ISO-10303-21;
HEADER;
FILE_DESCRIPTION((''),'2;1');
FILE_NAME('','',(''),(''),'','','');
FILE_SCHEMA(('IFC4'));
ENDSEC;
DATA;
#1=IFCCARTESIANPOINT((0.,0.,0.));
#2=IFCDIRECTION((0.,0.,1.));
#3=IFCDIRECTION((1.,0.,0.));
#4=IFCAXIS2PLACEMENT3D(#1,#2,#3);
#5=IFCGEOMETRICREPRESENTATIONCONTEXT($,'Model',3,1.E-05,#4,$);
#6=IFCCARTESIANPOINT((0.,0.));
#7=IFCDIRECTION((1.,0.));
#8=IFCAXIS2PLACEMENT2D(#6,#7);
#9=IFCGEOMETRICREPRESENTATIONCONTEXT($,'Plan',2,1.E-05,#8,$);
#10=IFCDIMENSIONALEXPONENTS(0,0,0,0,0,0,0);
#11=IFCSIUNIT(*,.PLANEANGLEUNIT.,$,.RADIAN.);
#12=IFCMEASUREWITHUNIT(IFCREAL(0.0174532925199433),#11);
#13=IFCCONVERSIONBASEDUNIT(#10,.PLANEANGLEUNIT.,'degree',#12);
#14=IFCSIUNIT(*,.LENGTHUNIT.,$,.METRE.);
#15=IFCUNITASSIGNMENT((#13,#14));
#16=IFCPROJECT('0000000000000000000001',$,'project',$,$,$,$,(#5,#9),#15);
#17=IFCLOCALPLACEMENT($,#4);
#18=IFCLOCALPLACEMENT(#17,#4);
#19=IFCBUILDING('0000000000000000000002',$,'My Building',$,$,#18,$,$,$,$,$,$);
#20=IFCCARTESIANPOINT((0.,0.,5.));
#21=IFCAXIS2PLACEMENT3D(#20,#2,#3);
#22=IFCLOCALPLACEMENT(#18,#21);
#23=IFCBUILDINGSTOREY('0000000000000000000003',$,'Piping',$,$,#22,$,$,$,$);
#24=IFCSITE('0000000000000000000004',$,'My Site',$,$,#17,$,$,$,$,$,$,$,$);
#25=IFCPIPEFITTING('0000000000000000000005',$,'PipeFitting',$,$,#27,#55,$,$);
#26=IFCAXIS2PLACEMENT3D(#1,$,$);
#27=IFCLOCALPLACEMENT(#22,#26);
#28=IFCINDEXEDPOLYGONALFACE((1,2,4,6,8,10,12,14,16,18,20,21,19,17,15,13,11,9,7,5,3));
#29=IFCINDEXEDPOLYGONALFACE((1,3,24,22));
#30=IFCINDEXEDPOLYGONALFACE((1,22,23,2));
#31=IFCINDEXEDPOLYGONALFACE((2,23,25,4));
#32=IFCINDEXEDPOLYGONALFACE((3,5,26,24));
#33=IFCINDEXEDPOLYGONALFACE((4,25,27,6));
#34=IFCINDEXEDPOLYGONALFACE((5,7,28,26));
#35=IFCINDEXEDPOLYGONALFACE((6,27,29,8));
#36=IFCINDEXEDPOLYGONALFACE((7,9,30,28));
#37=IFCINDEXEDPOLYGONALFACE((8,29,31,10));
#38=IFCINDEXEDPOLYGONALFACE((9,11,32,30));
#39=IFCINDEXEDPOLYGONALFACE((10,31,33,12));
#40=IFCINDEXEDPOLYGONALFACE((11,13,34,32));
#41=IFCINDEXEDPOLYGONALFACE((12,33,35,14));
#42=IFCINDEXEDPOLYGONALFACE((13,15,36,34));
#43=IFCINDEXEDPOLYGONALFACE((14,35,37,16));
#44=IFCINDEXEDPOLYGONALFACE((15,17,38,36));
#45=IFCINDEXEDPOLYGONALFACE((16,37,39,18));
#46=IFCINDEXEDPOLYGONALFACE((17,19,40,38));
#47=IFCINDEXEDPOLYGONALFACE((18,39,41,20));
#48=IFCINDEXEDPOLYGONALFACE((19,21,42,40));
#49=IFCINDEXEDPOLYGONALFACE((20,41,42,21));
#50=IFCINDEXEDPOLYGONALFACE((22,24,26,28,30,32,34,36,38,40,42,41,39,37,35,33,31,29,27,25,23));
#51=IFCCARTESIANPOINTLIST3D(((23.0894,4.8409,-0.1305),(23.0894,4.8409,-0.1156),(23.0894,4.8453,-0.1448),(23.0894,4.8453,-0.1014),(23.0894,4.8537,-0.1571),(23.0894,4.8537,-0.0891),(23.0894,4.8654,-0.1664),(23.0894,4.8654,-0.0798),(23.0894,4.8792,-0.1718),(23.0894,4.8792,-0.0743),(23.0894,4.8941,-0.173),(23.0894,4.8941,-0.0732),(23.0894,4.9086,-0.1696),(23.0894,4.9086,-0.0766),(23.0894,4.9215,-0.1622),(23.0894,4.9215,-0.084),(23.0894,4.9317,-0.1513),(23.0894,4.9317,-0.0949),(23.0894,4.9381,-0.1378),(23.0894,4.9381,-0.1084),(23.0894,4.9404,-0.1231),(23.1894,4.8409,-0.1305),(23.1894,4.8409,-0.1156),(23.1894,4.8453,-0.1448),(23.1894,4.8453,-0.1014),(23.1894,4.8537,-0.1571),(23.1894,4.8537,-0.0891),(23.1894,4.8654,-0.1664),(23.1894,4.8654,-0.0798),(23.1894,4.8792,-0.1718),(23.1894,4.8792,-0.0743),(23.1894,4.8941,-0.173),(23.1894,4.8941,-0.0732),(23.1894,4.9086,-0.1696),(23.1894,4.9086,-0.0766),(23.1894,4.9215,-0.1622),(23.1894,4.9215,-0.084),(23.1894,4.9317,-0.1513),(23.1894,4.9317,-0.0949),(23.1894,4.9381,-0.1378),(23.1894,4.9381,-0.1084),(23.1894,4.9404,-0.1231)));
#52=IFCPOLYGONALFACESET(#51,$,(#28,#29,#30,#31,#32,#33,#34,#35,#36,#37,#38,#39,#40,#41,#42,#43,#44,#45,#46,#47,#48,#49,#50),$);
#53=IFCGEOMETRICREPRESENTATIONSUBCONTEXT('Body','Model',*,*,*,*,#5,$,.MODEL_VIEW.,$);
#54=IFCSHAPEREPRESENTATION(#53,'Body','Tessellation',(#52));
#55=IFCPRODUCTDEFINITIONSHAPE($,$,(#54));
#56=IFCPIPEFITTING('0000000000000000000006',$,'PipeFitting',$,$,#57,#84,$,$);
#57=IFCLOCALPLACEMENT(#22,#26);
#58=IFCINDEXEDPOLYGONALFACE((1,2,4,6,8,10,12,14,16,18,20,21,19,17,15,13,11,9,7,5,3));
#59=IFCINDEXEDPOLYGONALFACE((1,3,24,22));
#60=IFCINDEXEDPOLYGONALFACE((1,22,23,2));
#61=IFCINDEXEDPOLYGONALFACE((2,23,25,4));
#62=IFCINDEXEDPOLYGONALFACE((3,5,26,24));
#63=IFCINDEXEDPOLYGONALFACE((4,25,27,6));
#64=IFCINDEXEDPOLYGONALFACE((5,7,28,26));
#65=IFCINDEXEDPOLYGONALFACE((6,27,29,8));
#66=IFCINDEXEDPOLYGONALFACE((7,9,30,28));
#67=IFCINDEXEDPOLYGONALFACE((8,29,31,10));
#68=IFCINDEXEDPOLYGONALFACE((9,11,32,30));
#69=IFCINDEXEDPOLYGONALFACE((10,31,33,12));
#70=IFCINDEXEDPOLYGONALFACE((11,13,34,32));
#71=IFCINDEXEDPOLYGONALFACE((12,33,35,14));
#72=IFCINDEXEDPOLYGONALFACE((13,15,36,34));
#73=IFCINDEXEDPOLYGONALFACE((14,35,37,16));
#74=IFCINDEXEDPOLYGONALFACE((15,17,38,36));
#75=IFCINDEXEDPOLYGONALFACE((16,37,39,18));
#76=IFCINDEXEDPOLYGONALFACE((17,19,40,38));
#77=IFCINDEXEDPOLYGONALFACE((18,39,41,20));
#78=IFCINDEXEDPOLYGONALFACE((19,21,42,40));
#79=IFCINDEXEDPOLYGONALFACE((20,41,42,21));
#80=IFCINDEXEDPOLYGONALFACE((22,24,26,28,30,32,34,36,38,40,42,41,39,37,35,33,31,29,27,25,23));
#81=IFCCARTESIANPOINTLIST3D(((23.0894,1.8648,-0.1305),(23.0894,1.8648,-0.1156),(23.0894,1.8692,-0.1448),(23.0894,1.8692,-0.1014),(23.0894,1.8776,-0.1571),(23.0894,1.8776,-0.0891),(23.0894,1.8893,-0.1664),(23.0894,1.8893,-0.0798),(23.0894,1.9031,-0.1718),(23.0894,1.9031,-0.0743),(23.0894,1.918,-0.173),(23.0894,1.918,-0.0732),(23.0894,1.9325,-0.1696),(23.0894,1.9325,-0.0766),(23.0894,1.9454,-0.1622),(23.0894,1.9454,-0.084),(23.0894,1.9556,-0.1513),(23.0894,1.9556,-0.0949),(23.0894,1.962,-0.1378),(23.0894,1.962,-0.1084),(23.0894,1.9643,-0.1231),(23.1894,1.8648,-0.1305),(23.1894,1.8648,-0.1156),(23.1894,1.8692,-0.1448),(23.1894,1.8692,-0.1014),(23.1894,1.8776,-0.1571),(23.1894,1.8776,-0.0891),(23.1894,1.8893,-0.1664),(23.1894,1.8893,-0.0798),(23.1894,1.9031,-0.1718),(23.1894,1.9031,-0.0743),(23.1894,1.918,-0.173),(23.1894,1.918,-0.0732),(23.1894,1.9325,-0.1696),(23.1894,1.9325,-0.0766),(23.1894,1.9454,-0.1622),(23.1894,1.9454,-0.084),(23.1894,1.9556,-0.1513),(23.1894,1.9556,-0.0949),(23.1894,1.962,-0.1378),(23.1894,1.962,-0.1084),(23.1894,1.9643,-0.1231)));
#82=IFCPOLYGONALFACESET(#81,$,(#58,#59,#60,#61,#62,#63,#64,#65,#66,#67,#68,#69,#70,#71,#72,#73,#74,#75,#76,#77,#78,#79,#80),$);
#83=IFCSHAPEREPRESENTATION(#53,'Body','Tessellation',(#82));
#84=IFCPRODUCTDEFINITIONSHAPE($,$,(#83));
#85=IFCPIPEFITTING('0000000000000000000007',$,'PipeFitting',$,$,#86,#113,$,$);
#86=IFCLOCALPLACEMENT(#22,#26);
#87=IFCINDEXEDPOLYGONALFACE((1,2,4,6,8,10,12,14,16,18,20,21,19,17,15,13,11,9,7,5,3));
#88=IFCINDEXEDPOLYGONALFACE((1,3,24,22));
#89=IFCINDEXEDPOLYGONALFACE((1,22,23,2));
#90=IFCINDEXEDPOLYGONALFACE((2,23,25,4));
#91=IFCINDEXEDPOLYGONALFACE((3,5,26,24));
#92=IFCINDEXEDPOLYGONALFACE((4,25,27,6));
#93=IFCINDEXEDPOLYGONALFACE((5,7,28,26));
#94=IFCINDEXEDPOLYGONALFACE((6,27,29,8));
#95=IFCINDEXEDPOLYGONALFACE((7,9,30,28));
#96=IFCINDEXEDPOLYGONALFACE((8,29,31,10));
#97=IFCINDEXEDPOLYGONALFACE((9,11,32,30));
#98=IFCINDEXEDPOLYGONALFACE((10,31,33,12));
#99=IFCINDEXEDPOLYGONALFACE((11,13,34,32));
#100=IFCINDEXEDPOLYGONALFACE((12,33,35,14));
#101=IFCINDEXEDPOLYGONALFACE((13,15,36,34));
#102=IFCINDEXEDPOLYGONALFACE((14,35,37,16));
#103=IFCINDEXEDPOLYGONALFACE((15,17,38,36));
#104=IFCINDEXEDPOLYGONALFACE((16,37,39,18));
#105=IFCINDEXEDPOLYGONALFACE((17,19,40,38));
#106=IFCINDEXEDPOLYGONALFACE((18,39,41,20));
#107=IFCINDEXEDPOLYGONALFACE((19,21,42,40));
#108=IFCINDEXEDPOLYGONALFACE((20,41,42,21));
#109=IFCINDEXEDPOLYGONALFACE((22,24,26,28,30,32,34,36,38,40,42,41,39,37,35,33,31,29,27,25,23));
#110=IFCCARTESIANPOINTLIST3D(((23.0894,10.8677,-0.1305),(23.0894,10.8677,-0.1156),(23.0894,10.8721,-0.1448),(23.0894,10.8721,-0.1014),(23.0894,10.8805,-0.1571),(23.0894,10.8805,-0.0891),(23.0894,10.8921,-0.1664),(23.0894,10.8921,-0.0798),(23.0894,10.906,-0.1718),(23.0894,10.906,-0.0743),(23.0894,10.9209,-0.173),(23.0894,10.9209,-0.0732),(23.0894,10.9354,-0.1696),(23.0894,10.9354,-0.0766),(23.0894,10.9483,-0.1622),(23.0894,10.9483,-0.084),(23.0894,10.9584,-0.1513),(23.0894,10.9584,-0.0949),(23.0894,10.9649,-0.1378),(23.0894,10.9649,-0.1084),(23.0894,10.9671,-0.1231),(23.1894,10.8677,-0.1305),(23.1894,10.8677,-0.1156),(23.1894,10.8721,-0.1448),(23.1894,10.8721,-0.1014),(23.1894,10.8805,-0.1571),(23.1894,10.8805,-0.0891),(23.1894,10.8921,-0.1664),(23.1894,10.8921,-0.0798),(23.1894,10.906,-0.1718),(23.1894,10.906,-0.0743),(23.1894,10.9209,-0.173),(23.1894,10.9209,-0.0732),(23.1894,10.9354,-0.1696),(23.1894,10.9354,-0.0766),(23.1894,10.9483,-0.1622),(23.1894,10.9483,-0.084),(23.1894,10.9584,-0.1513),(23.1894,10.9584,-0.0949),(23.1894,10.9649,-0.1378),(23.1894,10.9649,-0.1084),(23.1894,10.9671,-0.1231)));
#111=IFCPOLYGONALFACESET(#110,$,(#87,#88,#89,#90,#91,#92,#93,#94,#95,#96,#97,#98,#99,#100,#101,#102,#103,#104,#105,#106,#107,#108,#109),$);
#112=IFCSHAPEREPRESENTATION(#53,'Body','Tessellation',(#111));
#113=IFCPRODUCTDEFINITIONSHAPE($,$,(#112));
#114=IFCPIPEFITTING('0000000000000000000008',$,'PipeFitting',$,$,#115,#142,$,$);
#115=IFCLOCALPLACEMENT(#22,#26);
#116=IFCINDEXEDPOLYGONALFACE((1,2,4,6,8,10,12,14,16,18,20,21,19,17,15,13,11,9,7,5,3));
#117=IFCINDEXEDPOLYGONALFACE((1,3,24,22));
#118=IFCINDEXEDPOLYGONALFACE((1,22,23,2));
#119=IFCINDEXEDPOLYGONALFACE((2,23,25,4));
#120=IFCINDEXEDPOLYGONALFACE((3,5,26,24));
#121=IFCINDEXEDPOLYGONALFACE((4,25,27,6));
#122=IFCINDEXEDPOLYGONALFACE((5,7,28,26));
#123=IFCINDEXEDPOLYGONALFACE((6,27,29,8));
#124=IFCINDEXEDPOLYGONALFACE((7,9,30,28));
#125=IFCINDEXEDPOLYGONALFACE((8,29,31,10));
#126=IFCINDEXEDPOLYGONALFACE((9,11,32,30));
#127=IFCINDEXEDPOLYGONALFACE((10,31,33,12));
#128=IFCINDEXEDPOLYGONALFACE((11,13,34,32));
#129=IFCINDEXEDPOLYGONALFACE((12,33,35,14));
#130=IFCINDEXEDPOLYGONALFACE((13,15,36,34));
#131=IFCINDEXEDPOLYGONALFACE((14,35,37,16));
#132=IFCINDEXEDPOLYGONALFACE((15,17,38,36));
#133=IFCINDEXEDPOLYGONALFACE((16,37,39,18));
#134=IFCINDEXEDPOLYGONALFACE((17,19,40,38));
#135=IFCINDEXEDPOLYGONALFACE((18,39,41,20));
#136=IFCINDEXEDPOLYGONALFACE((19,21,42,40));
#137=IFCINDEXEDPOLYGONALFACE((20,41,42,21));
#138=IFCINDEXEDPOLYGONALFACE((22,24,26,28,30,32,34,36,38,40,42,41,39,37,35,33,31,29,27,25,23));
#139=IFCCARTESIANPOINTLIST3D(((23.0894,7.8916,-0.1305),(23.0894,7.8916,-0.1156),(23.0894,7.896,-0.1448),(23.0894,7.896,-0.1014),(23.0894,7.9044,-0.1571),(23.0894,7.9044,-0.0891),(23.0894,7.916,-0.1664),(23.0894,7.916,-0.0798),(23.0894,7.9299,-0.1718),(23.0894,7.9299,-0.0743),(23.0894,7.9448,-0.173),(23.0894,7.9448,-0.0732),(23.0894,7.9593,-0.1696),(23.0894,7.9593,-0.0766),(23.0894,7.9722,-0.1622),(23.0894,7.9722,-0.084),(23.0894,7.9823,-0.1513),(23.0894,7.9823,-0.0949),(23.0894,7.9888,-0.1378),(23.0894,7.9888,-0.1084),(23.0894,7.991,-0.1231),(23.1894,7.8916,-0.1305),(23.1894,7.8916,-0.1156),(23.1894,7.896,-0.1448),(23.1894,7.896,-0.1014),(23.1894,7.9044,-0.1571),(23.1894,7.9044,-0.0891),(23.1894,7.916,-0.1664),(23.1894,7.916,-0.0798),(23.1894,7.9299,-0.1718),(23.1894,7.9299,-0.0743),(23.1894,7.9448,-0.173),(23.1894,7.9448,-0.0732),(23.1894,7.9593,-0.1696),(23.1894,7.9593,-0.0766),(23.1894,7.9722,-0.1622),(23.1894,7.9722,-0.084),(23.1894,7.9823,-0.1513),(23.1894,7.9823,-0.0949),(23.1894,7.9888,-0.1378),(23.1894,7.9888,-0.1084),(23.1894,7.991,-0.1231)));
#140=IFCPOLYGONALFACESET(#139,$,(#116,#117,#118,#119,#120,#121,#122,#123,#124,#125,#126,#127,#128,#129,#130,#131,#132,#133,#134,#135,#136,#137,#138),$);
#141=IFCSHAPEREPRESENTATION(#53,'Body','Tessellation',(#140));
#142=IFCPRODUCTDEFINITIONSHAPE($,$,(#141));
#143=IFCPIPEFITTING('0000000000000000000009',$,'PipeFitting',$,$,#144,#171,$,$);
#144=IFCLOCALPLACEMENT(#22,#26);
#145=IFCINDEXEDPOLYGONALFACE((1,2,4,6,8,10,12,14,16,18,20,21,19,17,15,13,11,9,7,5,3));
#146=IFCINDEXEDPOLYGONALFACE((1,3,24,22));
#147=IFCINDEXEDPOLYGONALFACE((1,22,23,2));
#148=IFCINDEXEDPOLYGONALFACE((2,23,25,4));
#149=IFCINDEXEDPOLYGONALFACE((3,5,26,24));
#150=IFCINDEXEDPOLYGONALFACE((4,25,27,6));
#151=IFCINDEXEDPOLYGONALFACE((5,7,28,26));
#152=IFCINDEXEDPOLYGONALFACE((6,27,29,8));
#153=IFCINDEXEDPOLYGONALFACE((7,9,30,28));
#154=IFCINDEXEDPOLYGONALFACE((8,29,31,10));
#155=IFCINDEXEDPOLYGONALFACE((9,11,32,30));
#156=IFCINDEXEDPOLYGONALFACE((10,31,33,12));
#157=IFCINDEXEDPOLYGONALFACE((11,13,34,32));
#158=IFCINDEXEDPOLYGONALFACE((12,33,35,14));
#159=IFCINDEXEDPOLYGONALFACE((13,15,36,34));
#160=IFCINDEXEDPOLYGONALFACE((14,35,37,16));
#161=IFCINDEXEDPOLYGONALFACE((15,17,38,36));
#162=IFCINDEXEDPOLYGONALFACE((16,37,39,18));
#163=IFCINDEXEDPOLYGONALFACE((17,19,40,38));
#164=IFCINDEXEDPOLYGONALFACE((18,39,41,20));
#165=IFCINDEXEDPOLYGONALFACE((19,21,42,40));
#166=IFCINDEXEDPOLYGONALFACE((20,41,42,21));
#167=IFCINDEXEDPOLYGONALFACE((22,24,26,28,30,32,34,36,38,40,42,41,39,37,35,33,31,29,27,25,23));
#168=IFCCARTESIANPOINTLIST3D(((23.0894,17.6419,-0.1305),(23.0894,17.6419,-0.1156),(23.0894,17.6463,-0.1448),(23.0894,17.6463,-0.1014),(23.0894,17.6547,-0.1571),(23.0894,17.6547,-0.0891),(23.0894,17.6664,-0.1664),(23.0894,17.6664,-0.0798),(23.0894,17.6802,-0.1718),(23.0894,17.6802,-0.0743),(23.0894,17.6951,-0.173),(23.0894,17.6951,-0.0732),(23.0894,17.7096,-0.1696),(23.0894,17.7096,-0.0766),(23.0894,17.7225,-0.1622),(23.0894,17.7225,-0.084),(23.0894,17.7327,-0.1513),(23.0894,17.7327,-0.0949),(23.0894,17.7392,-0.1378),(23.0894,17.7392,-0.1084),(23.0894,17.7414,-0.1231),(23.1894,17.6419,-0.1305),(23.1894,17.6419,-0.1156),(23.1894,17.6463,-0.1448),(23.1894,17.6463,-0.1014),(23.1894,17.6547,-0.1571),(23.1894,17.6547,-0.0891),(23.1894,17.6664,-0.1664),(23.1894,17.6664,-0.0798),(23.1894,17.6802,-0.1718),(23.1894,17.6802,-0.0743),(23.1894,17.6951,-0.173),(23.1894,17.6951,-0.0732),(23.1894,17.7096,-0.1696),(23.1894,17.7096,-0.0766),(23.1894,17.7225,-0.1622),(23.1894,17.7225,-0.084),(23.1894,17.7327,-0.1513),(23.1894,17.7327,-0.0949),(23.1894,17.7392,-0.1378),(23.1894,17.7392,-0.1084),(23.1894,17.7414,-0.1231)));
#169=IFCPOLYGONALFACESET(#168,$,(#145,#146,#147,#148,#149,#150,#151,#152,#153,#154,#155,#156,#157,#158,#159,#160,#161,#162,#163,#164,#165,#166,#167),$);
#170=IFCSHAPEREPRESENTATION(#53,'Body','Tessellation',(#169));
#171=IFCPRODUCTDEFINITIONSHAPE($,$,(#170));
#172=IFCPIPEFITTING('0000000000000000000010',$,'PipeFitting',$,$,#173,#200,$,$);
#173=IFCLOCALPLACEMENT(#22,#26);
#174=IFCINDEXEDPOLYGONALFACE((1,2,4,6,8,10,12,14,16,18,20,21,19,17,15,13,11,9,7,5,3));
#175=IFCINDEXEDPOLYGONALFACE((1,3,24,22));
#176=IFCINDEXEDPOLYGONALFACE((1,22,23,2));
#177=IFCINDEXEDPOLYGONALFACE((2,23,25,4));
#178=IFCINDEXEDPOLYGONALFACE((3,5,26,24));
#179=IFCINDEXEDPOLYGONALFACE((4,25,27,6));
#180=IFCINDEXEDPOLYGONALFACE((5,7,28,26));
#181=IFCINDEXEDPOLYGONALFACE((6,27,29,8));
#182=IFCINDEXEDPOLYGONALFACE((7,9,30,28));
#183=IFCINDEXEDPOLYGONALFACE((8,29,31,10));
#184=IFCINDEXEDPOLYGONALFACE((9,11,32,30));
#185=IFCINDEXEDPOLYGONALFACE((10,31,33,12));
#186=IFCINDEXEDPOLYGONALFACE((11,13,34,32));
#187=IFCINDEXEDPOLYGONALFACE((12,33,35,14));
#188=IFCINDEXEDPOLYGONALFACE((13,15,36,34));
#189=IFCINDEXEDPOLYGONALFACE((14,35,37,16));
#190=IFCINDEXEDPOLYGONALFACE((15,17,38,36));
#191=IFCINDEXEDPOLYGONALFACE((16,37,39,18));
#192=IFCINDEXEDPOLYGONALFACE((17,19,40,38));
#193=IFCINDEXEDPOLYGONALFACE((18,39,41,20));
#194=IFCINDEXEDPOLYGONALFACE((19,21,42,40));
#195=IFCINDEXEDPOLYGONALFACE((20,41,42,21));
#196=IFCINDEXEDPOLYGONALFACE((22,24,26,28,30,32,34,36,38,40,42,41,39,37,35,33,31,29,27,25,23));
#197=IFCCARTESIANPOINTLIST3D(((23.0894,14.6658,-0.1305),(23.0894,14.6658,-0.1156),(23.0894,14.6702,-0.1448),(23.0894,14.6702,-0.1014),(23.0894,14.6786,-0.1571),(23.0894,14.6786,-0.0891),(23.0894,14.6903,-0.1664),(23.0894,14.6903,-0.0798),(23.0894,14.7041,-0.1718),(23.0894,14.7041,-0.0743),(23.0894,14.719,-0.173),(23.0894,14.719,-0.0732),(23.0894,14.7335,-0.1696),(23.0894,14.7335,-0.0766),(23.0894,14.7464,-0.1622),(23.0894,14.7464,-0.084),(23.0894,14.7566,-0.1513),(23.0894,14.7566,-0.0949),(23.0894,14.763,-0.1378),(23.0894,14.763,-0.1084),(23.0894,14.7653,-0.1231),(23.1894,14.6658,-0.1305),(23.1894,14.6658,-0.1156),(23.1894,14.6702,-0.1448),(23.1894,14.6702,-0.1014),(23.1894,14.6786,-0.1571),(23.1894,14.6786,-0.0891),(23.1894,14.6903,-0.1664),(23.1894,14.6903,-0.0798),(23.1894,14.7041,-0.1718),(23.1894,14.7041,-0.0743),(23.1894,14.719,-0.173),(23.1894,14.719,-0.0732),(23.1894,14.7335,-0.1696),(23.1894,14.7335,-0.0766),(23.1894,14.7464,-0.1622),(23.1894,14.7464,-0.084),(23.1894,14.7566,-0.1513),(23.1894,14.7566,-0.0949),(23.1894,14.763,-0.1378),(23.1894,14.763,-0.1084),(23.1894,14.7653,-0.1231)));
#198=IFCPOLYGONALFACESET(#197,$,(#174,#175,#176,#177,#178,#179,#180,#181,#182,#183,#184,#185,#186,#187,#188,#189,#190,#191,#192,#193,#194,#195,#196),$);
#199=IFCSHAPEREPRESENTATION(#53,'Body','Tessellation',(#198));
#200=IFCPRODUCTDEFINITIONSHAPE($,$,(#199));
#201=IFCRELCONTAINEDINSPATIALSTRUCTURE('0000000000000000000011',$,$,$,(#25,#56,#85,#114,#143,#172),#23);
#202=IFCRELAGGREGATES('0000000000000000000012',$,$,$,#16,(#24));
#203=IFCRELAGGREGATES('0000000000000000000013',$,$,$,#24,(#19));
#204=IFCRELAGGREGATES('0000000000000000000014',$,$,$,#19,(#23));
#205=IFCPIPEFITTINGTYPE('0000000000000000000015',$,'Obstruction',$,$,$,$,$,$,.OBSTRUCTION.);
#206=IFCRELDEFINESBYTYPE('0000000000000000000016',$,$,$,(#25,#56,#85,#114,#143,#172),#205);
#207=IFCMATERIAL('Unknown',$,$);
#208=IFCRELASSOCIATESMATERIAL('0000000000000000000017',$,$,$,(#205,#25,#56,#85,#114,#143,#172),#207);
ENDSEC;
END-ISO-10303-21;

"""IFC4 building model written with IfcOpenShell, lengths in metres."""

from ifc_helpers import new_model, entity, si_unit, converted_unit, frame, origin_with_axes, origin_2d_with_axis, place, context, subcontext, project, spatial, circle, extrude, material, material_profile, profile_set, profile_usage, type_object, element, save


model = new_model("IFC4")

# Units and contexts
model_context = context("Model", 3, precision=1e-05, world=origin_with_axes())
plan_context = context("Plan", 2, precision=1e-05, world=origin_2d_with_axis())
body_context = subcontext(model_context, "Body", "Model", "MODEL_VIEW")
ifc_project = project(units=[converted_unit("PLANEANGLEUNIT", "degree", entity("IfcReal", 0.0174532925199433), si_unit("PLANEANGLEUNIT", "RADIAN"), dimensions=[0, 0, 0, 0, 0, 0, 0]), si_unit("LENGTHUNIT", "METRE")], contexts=[model_context, plan_context])

# Site, building, storey
site_placement = place(None, origin_with_axes())
site = spatial("IfcSite", under=ifc_project, at=site_placement, Name="My Site")
building_placement = place(site_placement, origin_with_axes())
building = spatial("IfcBuilding", under=site, at=building_placement, Name="My Building")
storey_placement = place(building_placement, frame((0.0, 0.0, 5.0), z_axis=(0.0, 0.0, 1.0), x_axis=(1.0, 0.0, 0.0)))
storey = spatial("IfcBuildingStorey", under=building, at=storey_placement, Name="Piping")

# Shared definitions
ifc_material = material(Name="Unknown")

# Pipe fittings
ifc_material_profile_1 = material_profile(ifc_material, circle(Radius=0.05))
ifc_profile_set_1 = profile_set([ifc_material_profile_1])
ifc_profile_usage_1 = profile_usage(ifc_profile_set_1, cardinal=5)
pipe_fitting_type_1 = type_object("IfcPipeFittingType", Name="Obstruction", PredefinedType="OBSTRUCTION", material=ifc_profile_set_1)
pipe_fitting_1_placement = place(storey_placement, frame((23.0894, 4.8904, -0.1231), z_axis=(1.0, 0.0, 0.0), x_axis=(0.0, 1.0, 0.0)))
element("IfcPipeFitting", 1, at=pipe_fitting_1_placement, inside=storey, type_object=pipe_fitting_type_1, material=ifc_profile_usage_1, Name="PipeFitting", context=body_context, shape_type="SweptSolid", body=[
    extrude(circle(Radius=0.05), origin_with_axes(), (0.0, 0.0, 1.0), 0.1),
])
ifc_profile_usage_2 = profile_usage(ifc_profile_set_1, cardinal=5)
pipe_fitting_2_placement = place(storey_placement, frame((23.0894, 1.9143, -0.1231), z_axis=(1.0, 0.0, 0.0), x_axis=(0.0, 1.0, 0.0)))
element("IfcPipeFitting", 2, at=pipe_fitting_2_placement, inside=storey, type_object=pipe_fitting_type_1, material=ifc_profile_usage_2, Name="PipeFitting", context=body_context, shape_type="SweptSolid", body=[
    extrude(circle(Radius=0.05), origin_with_axes(), (0.0, 0.0, 1.0), 0.1),
])
ifc_profile_usage_3 = profile_usage(ifc_profile_set_1, cardinal=5)
pipe_fitting_3_placement = place(storey_placement, frame((23.0894, 10.9171, -0.1231), z_axis=(1.0, 0.0, 0.0), x_axis=(0.0, 1.0, 0.0)))
element("IfcPipeFitting", 3, at=pipe_fitting_3_placement, inside=storey, type_object=pipe_fitting_type_1, material=ifc_profile_usage_3, Name="PipeFitting", context=body_context, shape_type="SweptSolid", body=[
    extrude(circle(Radius=0.05), origin_with_axes(), (0.0, 0.0, 1.0), 0.1),
])
ifc_profile_usage_4 = profile_usage(ifc_profile_set_1, cardinal=5)
pipe_fitting_4_placement = place(storey_placement, frame((23.0894, 7.941, -0.1231), z_axis=(1.0, 0.0, 0.0), x_axis=(0.0, 1.0, 0.0)))
element("IfcPipeFitting", 4, at=pipe_fitting_4_placement, inside=storey, type_object=pipe_fitting_type_1, material=ifc_profile_usage_4, Name="PipeFitting", context=body_context, shape_type="SweptSolid", body=[
    extrude(circle(Radius=0.05), origin_with_axes(), (0.0, 0.0, 1.0), 0.1),
])
ifc_profile_usage_5 = profile_usage(ifc_profile_set_1, cardinal=5)
pipe_fitting_5_placement = place(storey_placement, frame((23.0894, 17.6914, -0.1231), z_axis=(1.0, 0.0, 0.0), x_axis=(0.0, 1.0, 0.0)))
element("IfcPipeFitting", 5, at=pipe_fitting_5_placement, inside=storey, type_object=pipe_fitting_type_1, material=ifc_profile_usage_5, Name="PipeFitting", context=body_context, shape_type="SweptSolid", body=[
    extrude(circle(Radius=0.05), origin_with_axes(), (0.0, 0.0, 1.0), 0.1),
])
ifc_profile_usage_6 = profile_usage(ifc_profile_set_1, cardinal=5)
pipe_fitting_6_placement = place(storey_placement, frame((23.0894, 14.7153, -0.1231), z_axis=(1.0, 0.0, 0.0), x_axis=(0.0, 1.0, 0.0)))
element("IfcPipeFitting", 6, at=pipe_fitting_6_placement, inside=storey, type_object=pipe_fitting_type_1, material=ifc_profile_usage_6, Name="PipeFitting", context=body_context, shape_type="SweptSolid", body=[
    extrude(circle(Radius=0.05), origin_with_axes(), (0.0, 0.0, 1.0), 0.1),
])

save(model, "model.ifc")
